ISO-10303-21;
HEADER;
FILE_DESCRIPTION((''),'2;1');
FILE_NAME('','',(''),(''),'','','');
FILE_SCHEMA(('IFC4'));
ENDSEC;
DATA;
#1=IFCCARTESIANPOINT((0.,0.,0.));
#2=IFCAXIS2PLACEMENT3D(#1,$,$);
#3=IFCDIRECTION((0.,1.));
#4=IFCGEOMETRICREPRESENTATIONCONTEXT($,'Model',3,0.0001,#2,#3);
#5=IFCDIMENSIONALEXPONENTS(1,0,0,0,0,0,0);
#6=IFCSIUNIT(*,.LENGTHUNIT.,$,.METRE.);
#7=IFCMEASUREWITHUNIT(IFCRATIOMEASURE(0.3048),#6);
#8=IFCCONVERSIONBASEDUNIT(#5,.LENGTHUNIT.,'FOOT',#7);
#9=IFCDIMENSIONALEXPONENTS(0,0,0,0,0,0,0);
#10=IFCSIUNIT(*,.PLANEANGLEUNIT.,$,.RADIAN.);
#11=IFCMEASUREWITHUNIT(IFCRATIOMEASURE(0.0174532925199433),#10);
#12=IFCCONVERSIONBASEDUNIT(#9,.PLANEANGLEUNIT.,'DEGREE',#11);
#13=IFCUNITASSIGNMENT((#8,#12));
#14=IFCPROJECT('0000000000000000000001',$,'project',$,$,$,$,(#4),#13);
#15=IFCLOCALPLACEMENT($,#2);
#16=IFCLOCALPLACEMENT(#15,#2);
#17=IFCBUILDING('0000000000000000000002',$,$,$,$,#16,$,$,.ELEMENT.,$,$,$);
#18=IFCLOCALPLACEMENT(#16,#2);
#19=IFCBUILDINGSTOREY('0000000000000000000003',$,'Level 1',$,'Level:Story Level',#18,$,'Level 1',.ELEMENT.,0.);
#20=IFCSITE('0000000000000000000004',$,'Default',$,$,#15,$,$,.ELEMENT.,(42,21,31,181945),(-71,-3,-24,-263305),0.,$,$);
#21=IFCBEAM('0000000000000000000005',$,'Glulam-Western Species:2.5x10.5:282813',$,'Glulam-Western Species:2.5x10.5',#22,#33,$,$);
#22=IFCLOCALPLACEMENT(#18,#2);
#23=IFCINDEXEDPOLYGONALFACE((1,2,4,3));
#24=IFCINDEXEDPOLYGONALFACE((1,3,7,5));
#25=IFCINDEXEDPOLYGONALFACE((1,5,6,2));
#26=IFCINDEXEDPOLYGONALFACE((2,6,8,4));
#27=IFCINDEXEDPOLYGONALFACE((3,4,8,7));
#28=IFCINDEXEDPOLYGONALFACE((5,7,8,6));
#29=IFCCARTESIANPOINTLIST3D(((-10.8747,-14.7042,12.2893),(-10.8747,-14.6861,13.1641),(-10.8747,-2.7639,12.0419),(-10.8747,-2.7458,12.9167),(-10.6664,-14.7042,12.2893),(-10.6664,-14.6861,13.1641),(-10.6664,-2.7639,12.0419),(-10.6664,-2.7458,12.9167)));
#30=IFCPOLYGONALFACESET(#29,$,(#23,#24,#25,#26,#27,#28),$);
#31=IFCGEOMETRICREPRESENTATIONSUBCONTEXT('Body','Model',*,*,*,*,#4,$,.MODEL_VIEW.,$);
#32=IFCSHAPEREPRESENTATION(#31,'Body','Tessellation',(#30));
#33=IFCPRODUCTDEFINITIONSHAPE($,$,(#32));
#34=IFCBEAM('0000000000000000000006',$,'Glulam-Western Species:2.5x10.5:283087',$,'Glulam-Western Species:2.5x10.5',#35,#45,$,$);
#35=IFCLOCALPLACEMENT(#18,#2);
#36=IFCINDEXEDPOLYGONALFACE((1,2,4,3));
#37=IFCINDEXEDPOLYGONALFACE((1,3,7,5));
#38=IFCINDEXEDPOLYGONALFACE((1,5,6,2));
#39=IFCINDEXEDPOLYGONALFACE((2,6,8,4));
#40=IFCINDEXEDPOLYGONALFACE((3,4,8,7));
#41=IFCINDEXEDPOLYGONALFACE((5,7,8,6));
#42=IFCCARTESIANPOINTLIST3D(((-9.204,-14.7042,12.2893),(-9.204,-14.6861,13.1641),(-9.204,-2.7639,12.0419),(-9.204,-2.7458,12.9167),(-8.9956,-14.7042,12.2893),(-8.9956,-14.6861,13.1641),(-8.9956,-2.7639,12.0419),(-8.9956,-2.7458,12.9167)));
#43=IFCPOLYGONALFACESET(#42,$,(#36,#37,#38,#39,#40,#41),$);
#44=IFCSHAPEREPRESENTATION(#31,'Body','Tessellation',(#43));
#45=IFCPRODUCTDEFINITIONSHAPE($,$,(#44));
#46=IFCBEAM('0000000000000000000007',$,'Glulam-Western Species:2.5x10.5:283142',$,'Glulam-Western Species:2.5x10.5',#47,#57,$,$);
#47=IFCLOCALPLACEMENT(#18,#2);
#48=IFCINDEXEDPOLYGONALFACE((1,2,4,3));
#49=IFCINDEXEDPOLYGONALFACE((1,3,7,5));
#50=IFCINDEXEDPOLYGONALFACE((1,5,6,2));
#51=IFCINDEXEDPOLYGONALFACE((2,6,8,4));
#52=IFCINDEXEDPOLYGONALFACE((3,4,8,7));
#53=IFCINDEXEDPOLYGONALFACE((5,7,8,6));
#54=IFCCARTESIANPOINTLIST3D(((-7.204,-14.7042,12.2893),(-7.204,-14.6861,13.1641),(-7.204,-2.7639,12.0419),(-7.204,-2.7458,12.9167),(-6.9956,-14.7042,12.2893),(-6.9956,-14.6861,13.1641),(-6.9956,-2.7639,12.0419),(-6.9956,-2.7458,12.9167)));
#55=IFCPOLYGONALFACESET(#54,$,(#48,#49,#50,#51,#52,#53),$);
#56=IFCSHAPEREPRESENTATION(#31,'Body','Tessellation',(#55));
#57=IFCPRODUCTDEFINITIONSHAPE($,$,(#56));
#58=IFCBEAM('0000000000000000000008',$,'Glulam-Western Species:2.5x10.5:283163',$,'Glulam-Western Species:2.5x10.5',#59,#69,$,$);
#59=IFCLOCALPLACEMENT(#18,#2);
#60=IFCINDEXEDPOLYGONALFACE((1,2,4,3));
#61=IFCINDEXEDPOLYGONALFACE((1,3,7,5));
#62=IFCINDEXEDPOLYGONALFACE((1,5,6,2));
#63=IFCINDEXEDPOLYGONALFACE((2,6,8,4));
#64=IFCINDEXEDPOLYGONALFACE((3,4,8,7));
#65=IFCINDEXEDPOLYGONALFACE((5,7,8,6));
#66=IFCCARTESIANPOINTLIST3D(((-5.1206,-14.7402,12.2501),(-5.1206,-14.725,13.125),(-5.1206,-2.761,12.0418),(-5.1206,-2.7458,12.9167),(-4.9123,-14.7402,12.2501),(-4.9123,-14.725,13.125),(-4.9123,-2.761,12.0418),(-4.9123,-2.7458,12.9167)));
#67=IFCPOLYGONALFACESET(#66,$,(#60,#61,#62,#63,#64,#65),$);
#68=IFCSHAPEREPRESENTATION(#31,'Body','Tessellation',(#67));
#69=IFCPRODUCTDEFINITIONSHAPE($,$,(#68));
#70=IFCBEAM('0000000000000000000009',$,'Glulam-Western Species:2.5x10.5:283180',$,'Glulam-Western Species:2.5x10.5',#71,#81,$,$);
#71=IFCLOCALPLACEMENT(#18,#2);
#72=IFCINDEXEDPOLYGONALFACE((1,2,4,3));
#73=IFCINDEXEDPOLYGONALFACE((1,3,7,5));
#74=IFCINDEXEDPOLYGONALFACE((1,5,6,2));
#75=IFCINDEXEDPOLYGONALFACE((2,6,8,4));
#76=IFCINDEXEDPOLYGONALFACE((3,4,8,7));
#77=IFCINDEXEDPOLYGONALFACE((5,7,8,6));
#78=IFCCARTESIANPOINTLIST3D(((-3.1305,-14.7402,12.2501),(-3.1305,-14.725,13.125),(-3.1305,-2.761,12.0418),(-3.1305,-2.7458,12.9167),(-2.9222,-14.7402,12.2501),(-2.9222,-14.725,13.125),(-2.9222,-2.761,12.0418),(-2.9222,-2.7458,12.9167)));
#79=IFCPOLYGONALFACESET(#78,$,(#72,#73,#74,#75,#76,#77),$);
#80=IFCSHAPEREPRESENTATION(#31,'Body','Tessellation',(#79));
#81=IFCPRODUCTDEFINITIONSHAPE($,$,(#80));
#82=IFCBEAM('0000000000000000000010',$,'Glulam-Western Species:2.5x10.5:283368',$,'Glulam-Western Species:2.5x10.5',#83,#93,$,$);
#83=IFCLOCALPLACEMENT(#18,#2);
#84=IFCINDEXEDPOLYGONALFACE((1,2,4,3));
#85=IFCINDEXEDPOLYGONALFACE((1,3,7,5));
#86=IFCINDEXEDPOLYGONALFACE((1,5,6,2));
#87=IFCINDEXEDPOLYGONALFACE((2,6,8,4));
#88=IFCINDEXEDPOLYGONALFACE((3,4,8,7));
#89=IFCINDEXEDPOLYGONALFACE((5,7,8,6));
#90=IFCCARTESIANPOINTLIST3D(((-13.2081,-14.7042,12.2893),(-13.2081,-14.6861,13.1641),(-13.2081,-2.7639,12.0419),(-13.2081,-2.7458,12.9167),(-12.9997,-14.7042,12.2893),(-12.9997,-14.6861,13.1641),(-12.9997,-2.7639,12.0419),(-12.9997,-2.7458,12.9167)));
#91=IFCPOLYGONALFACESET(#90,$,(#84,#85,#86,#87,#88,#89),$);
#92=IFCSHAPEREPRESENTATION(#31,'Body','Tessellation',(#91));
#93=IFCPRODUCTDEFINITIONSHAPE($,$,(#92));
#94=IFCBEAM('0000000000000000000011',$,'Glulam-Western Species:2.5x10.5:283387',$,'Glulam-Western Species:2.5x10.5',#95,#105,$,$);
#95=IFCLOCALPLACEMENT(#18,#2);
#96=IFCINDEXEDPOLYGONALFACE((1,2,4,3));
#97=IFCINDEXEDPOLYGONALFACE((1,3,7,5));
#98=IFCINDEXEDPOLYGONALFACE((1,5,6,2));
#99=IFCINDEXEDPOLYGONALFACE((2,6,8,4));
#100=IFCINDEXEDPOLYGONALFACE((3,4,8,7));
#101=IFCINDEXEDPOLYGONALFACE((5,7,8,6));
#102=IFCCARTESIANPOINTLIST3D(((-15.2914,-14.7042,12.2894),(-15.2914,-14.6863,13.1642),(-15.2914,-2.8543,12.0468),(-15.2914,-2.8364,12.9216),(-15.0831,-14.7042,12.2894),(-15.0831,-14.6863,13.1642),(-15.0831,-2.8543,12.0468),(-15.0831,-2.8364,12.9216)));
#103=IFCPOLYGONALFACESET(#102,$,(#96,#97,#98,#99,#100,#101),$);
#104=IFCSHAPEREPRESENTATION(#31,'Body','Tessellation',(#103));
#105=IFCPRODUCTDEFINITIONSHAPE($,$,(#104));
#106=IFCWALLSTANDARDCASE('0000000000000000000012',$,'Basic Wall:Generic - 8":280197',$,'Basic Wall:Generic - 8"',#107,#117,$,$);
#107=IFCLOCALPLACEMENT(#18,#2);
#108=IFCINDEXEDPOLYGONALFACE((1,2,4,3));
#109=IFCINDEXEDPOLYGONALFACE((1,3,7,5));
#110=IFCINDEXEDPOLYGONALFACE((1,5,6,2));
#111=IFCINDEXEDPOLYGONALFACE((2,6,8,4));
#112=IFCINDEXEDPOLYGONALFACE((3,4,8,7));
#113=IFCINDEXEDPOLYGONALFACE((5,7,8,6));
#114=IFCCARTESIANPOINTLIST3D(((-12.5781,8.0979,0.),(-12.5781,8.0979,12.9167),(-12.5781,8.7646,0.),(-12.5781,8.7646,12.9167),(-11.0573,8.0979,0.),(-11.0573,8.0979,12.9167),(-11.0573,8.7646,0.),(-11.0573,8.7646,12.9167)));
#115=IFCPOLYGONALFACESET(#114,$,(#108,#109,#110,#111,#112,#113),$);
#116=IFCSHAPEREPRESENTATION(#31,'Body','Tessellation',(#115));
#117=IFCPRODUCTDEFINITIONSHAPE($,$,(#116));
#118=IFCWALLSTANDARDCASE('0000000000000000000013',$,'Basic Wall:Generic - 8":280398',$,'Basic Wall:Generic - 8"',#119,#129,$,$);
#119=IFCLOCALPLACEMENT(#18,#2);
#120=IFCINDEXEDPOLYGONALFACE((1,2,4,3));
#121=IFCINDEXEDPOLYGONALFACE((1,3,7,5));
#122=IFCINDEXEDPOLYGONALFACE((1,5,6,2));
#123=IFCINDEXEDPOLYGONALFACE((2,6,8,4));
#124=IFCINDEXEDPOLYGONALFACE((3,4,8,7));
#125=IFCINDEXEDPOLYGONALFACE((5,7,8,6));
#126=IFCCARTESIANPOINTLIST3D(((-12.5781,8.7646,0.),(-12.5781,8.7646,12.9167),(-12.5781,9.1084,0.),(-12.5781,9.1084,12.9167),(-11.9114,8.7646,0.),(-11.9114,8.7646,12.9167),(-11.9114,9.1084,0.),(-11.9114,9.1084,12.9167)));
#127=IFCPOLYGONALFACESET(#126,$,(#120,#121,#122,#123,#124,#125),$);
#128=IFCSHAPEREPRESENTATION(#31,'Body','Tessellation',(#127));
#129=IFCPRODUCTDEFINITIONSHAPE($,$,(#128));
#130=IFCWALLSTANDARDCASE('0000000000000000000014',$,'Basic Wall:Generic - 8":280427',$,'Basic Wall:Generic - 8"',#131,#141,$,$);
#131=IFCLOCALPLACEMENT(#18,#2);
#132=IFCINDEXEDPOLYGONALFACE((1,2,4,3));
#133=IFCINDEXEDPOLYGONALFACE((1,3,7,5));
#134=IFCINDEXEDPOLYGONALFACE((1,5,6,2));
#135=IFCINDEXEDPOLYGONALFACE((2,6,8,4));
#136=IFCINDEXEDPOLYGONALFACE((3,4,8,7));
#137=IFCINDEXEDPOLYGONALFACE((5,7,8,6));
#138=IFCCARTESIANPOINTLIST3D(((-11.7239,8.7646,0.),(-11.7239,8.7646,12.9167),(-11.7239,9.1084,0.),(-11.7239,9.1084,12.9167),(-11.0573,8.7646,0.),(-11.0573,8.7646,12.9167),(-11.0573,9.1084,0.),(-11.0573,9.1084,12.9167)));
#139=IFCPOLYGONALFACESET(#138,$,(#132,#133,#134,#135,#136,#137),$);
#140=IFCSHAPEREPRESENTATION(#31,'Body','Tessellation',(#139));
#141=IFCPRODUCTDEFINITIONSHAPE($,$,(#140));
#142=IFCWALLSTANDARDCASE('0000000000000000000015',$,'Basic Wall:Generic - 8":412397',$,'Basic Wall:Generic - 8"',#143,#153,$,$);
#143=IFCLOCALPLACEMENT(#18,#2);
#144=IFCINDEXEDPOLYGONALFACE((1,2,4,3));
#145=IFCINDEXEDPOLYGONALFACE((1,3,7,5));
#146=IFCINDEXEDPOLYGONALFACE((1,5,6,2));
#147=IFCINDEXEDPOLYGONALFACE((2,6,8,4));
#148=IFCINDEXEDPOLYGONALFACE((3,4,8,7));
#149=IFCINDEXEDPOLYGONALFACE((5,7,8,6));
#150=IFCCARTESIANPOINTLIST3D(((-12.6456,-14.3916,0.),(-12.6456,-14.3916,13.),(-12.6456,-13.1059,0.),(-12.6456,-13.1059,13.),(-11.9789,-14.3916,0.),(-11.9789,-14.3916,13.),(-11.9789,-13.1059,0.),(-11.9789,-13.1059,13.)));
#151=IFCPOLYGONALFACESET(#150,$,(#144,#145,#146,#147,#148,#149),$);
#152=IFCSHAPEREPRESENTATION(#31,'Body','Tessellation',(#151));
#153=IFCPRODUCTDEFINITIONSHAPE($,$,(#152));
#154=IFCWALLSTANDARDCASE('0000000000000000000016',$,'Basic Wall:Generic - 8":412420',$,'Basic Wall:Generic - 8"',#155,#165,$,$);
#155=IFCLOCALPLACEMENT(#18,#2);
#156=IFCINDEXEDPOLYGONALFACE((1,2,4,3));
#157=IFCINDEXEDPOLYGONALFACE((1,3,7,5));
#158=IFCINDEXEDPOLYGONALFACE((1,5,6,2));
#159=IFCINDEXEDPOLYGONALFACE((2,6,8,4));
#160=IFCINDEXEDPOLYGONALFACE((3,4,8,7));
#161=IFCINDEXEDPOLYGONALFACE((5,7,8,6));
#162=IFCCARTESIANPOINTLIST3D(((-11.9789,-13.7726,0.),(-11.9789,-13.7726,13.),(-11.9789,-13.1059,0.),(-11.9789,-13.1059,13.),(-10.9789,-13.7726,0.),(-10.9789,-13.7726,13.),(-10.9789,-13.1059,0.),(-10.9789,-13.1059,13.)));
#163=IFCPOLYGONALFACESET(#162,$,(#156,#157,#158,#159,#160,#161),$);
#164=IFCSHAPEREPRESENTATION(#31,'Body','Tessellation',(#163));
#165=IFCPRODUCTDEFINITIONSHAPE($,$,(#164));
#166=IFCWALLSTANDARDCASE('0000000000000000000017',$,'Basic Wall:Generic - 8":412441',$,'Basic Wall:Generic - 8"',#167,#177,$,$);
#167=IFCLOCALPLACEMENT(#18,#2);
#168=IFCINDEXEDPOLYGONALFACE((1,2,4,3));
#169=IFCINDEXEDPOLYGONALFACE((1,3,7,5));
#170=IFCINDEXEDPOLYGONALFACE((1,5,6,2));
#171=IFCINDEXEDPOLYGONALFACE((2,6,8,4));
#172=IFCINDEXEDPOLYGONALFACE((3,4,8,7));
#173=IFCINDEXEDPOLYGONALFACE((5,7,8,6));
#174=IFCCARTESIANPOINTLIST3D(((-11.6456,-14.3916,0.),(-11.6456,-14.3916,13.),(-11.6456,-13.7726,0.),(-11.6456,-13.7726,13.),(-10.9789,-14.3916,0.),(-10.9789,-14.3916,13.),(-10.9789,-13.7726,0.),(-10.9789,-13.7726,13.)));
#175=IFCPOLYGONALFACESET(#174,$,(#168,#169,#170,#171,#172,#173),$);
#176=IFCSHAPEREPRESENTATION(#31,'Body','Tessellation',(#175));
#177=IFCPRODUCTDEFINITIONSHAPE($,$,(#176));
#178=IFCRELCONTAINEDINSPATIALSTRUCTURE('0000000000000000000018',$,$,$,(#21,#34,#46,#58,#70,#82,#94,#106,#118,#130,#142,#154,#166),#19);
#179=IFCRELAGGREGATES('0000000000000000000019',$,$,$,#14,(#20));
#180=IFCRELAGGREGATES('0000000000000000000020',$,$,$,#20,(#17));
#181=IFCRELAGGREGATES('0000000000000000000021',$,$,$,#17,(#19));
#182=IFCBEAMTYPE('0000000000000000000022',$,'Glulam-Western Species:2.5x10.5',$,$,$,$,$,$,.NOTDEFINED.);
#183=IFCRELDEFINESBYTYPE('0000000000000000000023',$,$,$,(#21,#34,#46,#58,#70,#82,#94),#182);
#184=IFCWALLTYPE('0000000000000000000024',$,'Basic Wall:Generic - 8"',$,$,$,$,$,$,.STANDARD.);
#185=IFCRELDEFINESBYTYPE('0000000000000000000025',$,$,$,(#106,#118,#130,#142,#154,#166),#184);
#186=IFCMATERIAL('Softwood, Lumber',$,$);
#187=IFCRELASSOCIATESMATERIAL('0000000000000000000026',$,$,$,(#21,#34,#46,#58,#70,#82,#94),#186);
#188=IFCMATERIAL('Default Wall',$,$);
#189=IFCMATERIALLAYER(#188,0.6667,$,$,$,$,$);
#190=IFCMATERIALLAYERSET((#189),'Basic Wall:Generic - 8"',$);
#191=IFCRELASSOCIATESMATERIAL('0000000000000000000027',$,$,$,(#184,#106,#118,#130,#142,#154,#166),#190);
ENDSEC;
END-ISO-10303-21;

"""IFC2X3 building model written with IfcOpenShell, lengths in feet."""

from ifc_helpers import new_model, entity, si_unit, converted_unit, direction, frame, frame_2d, origin, origin_2d_with_axis, place, context, subcontext, project, spatial, rectangle, extrude, material, layer, layer_set, layer_usage, type_object, element, save


model = new_model("IFC2X3")

# Units and contexts
model_context = context("Model", 3, precision=0.0001, world=origin(), true_north=direction((0.0, 1.0)))
body_context = subcontext(model_context, "Body", "Model", "MODEL_VIEW")
ifc_project = project(units=[converted_unit("LENGTHUNIT", "FOOT", entity("IfcRatioMeasure", 0.3048), si_unit("LENGTHUNIT", "METRE"), dimensions=[1, 0, 0, 0, 0, 0, 0]), converted_unit("PLANEANGLEUNIT", "DEGREE", entity("IfcRatioMeasure", 0.0174532925199433), si_unit("PLANEANGLEUNIT", "RADIAN"), dimensions=[0, 0, 0, 0, 0, 0, 0])], contexts=[model_context])

# Site, building, storey
site_placement = place(None, origin())
site = spatial("IfcSite", under=ifc_project, at=site_placement, Name="Default", CompositionType="ELEMENT", RefLatitude=(42, 21, 31, 181945), RefLongitude=(-71, -3, -24, -263305), RefElevation=0.0)
building_placement = place(site_placement, origin())
building = spatial("IfcBuilding", under=site, at=building_placement, CompositionType="ELEMENT")
storey_placement = place(building_placement, origin())
storey = spatial("IfcBuildingStorey", under=building, at=storey_placement, Name="Level 1", ObjectType="Level:Story Level", LongName="Level 1", CompositionType="ELEMENT", Elevation=0.0)

# Beams
ifc_material_1 = material(Name="Softwood, Lumber")
beam_type = type_object("IfcBeamType", Name="Glulam-Western Species:2.5x10.5", PredefinedType="NOTDEFINED")
beam_1_placement = place(storey_placement, frame((-10.7706, -2.7458, 12.9167), z_axis=(0.0, 0.020721, 0.999785), x_axis=(0.0, -0.999785, 0.020721)))
element("IfcBeam", 1, at=beam_1_placement, inside=storey, type_object=beam_type, material=ifc_material_1, Name="Glulam-Western Species:2.5x10.5:282813", ObjectType="Glulam-Western Species:2.5x10.5", context=body_context, shape_type="SweptSolid", body=[
    extrude(rectangle(XDim=0.875, YDim=0.2083, at=origin_2d_with_axis()), frame((0.0, 0.0, -0.4375), z_axis=(1.0, 0.0, 0.0), x_axis=(0.0, 0.0, -1.0)), (0.0, 0.0, 1.0), 11.9428),
])
beam_2_placement = place(storey_placement, frame((-9.0998, -2.7458, 12.9167), z_axis=(0.0, 0.020721, 0.999785), x_axis=(0.0, -0.999785, 0.020721)))
element("IfcBeam", 2, at=beam_2_placement, inside=storey, type_object=beam_type, material=ifc_material_1, Name="Glulam-Western Species:2.5x10.5:283087", ObjectType="Glulam-Western Species:2.5x10.5", context=body_context, shape_type="SweptSolid", body=[
    extrude(rectangle(XDim=0.875, YDim=0.2083, at=origin_2d_with_axis()), frame((0.0, 0.0, -0.4375), z_axis=(1.0, 0.0, 0.0), x_axis=(0.0, 0.0, -1.0)), (0.0, 0.0, 1.0), 11.9428),
])
beam_3_placement = place(storey_placement, frame((-7.0998, -2.7458, 12.9167), z_axis=(0.0, 0.020721, 0.999785), x_axis=(0.0, -0.999785, 0.020721)))
element("IfcBeam", 3, at=beam_3_placement, inside=storey, type_object=beam_type, material=ifc_material_1, Name="Glulam-Western Species:2.5x10.5:283142", ObjectType="Glulam-Western Species:2.5x10.5", context=body_context, shape_type="SweptSolid", body=[
    extrude(rectangle(XDim=0.875, YDim=0.2083, at=origin_2d_with_axis()), frame((0.0, 0.0, -0.4375), z_axis=(1.0, 0.0, 0.0), x_axis=(0.0, 0.0, -1.0)), (0.0, 0.0, 1.0), 11.9428),
])
beam_4_placement = place(storey_placement, frame((-5.0165, -2.7458, 12.9167), z_axis=(0.0, 0.017389, 0.999849), x_axis=(0.0, -0.999849, 0.017389)))
element("IfcBeam", 4, at=beam_4_placement, inside=storey, type_object=beam_type, material=ifc_material_1, Name="Glulam-Western Species:2.5x10.5:283163", ObjectType="Glulam-Western Species:2.5x10.5", context=body_context, shape_type="SweptSolid", body=[
    extrude(rectangle(XDim=0.875, YDim=0.2083, at=origin_2d_with_axis()), frame((0.0, 0.0, -0.4375), z_axis=(1.0, 0.0, 0.0), x_axis=(0.0, 0.0, -1.0)), (0.0, 0.0, 1.0), 11.981),
])
beam_5_placement = place(storey_placement, frame((-3.0263, -2.7458, 12.9167), z_axis=(0.0, 0.017389, 0.999849), x_axis=(0.0, -0.999849, 0.017389)))
element("IfcBeam", 5, at=beam_5_placement, inside=storey, type_object=beam_type, material=ifc_material_1, Name="Glulam-Western Species:2.5x10.5:283180", ObjectType="Glulam-Western Species:2.5x10.5", context=body_context, shape_type="SweptSolid", body=[
    extrude(rectangle(XDim=0.875, YDim=0.2083, at=origin_2d_with_axis()), frame((0.0, 0.0, -0.4375), z_axis=(1.0, 0.0, 0.0), x_axis=(0.0, 0.0, -1.0)), (0.0, 0.0, 1.0), 11.981),
])
beam_6_placement = place(storey_placement, frame((-13.1039, -2.7458, 12.9167), z_axis=(0.0, 0.020721, 0.999785), x_axis=(0.0, -0.999785, 0.020721)))
element("IfcBeam", 6, at=beam_6_placement, inside=storey, type_object=beam_type, material=ifc_material_1, Name="Glulam-Western Species:2.5x10.5:283368", ObjectType="Glulam-Western Species:2.5x10.5", context=body_context, shape_type="SweptSolid", body=[
    extrude(rectangle(XDim=0.875, YDim=0.2083, at=origin_2d_with_axis()), frame((0.0, 0.0, -0.4375), z_axis=(1.0, 0.0, 0.0), x_axis=(0.0, 0.0, -1.0)), (0.0, 0.0, 1.0), 11.9428),
])
beam_7_placement = place(storey_placement, frame((-15.1872, -2.7322, 12.9195), z_axis=(0.0, 0.020465, 0.999791), x_axis=(0.0, -0.999791, 0.020465)))
element("IfcBeam", 7, at=beam_7_placement, inside=storey, type_object=beam_type, material=ifc_material_1, Name="Glulam-Western Species:2.5x10.5:283387", ObjectType="Glulam-Western Species:2.5x10.5", context=body_context, shape_type="SweptSolid", body=[
    extrude(rectangle(XDim=0.875, YDim=0.2083, at=frame_2d((0.0, 0.0), x_axis=(1.0, 0.0))), frame((0.1041, 0.0, -0.4375), z_axis=(1.0, 0.0, 0.0), x_axis=(0.0, 0.0, -1.0)), (0.0, 0.0, 1.0), 11.8524),
])

# Walls
ifc_material_2 = material(Name="Default Wall")
ifc_layer = layer(ifc_material_2, 0.6667)
ifc_layer_set = layer_set([ifc_layer], Name="Basic Wall:Generic - 8\"")
ifc_layer_usage_1 = layer_usage(ifc_layer_set, "AXIS2", "NEGATIVE", 0.3333)
wall_type = type_object("IfcWallType", Name="Basic Wall:Generic - 8\"", PredefinedType="STANDARD", material=ifc_layer_set)
wall_1_placement = place(storey_placement, frame((-12.5781, 8.4313, 0.0)))
element("IfcWallStandardCase", 8, at=wall_1_placement, inside=storey, type_object=wall_type, material=ifc_layer_usage_1, Name="Basic Wall:Generic - 8\":280197", ObjectType="Basic Wall:Generic - 8\"", context=body_context, shape_type="SweptSolid", body=[
    extrude(rectangle(XDim=1.5208, YDim=0.6667, at=frame_2d((0.7604, 0.0), x_axis=(-1.0, 0.0))), origin(), (0.0, 0.0, 1.0), 12.9167),
])
ifc_layer_usage_2 = layer_usage(ifc_layer_set, "AXIS2", "NEGATIVE", 0.3333)
wall_2_placement = place(storey_placement, frame((-12.2448, 8.7646, 0.0), z_axis=(0.0, 0.0, 1.0), x_axis=(0.0, 1.0, 0.0)))
element("IfcWallStandardCase", 9, at=wall_2_placement, inside=storey, type_object=wall_type, material=ifc_layer_usage_2, Name="Basic Wall:Generic - 8\":280398", ObjectType="Basic Wall:Generic - 8\"", context=body_context, shape_type="SweptSolid", body=[
    extrude(rectangle(XDim=0.3438, YDim=0.6667, at=frame_2d((0.1719, 0.0), x_axis=(-1.0, 0.0))), origin(), (0.0, 0.0, 1.0), 12.9167),
])
ifc_layer_usage_3 = layer_usage(ifc_layer_set, "AXIS2", "NEGATIVE", 0.3333)
wall_3_placement = place(storey_placement, frame((-11.3906, 8.7646, 0.0), z_axis=(0.0, 0.0, 1.0), x_axis=(0.0, 1.0, 0.0)))
element("IfcWallStandardCase", 10, at=wall_3_placement, inside=storey, type_object=wall_type, material=ifc_layer_usage_3, Name="Basic Wall:Generic - 8\":280427", ObjectType="Basic Wall:Generic - 8\"", context=body_context, shape_type="SweptSolid", body=[
    extrude(rectangle(XDim=0.3438, YDim=0.6667, at=frame_2d((0.1719, 0.0), x_axis=(-1.0, 0.0))), origin(), (0.0, 0.0, 1.0), 12.9167),
])
ifc_layer_usage_4 = layer_usage(ifc_layer_set, "AXIS2", "NEGATIVE", 0.3333)
wall_4_placement = place(storey_placement, frame((-12.3122, -14.3916, 0.0), z_axis=(0.0, 0.0, 1.0), x_axis=(0.0, 1.0, 0.0)))
element("IfcWallStandardCase", 11, at=wall_4_placement, inside=storey, type_object=wall_type, material=ifc_layer_usage_4, Name="Basic Wall:Generic - 8\":412397", ObjectType="Basic Wall:Generic - 8\"", context=body_context, shape_type="SweptSolid", body=[
    extrude(rectangle(XDim=1.2857, YDim=0.6667, at=frame_2d((0.6429, 0.0), x_axis=(-1.0, 0.0))), origin(), (0.0, 0.0, 1.0), 13.0),
])
ifc_layer_usage_5 = layer_usage(ifc_layer_set, "AXIS2", "NEGATIVE", 0.3333)
wall_5_placement = place(storey_placement, frame((-11.9789, -13.4393, 0.0)))
element("IfcWallStandardCase", 12, at=wall_5_placement, inside=storey, type_object=wall_type, material=ifc_layer_usage_5, Name="Basic Wall:Generic - 8\":412420", ObjectType="Basic Wall:Generic - 8\"", context=body_context, shape_type="SweptSolid", body=[
    extrude(rectangle(XDim=1.0, YDim=0.6667, at=frame_2d((0.5, 0.0), x_axis=(-1.0, 0.0))), origin(), (0.0, 0.0, 1.0), 13.0),
])
ifc_layer_usage_6 = layer_usage(ifc_layer_set, "AXIS2", "NEGATIVE", 0.3333)
wall_6_placement = place(storey_placement, frame((-11.3122, -13.7726, 0.0), z_axis=(0.0, 0.0, 1.0), x_axis=(0.0, -1.0, 0.0)))
element("IfcWallStandardCase", 13, at=wall_6_placement, inside=storey, type_object=wall_type, material=ifc_layer_usage_6, Name="Basic Wall:Generic - 8\":412441", ObjectType="Basic Wall:Generic - 8\"", context=body_context, shape_type="SweptSolid", body=[
    extrude(rectangle(XDim=0.619, YDim=0.6667, at=frame_2d((0.3095, 0.0), x_axis=(-1.0, 0.0))), origin(), (0.0, 0.0, 1.0), 13.0),
])

save(model, "model.ifc")
